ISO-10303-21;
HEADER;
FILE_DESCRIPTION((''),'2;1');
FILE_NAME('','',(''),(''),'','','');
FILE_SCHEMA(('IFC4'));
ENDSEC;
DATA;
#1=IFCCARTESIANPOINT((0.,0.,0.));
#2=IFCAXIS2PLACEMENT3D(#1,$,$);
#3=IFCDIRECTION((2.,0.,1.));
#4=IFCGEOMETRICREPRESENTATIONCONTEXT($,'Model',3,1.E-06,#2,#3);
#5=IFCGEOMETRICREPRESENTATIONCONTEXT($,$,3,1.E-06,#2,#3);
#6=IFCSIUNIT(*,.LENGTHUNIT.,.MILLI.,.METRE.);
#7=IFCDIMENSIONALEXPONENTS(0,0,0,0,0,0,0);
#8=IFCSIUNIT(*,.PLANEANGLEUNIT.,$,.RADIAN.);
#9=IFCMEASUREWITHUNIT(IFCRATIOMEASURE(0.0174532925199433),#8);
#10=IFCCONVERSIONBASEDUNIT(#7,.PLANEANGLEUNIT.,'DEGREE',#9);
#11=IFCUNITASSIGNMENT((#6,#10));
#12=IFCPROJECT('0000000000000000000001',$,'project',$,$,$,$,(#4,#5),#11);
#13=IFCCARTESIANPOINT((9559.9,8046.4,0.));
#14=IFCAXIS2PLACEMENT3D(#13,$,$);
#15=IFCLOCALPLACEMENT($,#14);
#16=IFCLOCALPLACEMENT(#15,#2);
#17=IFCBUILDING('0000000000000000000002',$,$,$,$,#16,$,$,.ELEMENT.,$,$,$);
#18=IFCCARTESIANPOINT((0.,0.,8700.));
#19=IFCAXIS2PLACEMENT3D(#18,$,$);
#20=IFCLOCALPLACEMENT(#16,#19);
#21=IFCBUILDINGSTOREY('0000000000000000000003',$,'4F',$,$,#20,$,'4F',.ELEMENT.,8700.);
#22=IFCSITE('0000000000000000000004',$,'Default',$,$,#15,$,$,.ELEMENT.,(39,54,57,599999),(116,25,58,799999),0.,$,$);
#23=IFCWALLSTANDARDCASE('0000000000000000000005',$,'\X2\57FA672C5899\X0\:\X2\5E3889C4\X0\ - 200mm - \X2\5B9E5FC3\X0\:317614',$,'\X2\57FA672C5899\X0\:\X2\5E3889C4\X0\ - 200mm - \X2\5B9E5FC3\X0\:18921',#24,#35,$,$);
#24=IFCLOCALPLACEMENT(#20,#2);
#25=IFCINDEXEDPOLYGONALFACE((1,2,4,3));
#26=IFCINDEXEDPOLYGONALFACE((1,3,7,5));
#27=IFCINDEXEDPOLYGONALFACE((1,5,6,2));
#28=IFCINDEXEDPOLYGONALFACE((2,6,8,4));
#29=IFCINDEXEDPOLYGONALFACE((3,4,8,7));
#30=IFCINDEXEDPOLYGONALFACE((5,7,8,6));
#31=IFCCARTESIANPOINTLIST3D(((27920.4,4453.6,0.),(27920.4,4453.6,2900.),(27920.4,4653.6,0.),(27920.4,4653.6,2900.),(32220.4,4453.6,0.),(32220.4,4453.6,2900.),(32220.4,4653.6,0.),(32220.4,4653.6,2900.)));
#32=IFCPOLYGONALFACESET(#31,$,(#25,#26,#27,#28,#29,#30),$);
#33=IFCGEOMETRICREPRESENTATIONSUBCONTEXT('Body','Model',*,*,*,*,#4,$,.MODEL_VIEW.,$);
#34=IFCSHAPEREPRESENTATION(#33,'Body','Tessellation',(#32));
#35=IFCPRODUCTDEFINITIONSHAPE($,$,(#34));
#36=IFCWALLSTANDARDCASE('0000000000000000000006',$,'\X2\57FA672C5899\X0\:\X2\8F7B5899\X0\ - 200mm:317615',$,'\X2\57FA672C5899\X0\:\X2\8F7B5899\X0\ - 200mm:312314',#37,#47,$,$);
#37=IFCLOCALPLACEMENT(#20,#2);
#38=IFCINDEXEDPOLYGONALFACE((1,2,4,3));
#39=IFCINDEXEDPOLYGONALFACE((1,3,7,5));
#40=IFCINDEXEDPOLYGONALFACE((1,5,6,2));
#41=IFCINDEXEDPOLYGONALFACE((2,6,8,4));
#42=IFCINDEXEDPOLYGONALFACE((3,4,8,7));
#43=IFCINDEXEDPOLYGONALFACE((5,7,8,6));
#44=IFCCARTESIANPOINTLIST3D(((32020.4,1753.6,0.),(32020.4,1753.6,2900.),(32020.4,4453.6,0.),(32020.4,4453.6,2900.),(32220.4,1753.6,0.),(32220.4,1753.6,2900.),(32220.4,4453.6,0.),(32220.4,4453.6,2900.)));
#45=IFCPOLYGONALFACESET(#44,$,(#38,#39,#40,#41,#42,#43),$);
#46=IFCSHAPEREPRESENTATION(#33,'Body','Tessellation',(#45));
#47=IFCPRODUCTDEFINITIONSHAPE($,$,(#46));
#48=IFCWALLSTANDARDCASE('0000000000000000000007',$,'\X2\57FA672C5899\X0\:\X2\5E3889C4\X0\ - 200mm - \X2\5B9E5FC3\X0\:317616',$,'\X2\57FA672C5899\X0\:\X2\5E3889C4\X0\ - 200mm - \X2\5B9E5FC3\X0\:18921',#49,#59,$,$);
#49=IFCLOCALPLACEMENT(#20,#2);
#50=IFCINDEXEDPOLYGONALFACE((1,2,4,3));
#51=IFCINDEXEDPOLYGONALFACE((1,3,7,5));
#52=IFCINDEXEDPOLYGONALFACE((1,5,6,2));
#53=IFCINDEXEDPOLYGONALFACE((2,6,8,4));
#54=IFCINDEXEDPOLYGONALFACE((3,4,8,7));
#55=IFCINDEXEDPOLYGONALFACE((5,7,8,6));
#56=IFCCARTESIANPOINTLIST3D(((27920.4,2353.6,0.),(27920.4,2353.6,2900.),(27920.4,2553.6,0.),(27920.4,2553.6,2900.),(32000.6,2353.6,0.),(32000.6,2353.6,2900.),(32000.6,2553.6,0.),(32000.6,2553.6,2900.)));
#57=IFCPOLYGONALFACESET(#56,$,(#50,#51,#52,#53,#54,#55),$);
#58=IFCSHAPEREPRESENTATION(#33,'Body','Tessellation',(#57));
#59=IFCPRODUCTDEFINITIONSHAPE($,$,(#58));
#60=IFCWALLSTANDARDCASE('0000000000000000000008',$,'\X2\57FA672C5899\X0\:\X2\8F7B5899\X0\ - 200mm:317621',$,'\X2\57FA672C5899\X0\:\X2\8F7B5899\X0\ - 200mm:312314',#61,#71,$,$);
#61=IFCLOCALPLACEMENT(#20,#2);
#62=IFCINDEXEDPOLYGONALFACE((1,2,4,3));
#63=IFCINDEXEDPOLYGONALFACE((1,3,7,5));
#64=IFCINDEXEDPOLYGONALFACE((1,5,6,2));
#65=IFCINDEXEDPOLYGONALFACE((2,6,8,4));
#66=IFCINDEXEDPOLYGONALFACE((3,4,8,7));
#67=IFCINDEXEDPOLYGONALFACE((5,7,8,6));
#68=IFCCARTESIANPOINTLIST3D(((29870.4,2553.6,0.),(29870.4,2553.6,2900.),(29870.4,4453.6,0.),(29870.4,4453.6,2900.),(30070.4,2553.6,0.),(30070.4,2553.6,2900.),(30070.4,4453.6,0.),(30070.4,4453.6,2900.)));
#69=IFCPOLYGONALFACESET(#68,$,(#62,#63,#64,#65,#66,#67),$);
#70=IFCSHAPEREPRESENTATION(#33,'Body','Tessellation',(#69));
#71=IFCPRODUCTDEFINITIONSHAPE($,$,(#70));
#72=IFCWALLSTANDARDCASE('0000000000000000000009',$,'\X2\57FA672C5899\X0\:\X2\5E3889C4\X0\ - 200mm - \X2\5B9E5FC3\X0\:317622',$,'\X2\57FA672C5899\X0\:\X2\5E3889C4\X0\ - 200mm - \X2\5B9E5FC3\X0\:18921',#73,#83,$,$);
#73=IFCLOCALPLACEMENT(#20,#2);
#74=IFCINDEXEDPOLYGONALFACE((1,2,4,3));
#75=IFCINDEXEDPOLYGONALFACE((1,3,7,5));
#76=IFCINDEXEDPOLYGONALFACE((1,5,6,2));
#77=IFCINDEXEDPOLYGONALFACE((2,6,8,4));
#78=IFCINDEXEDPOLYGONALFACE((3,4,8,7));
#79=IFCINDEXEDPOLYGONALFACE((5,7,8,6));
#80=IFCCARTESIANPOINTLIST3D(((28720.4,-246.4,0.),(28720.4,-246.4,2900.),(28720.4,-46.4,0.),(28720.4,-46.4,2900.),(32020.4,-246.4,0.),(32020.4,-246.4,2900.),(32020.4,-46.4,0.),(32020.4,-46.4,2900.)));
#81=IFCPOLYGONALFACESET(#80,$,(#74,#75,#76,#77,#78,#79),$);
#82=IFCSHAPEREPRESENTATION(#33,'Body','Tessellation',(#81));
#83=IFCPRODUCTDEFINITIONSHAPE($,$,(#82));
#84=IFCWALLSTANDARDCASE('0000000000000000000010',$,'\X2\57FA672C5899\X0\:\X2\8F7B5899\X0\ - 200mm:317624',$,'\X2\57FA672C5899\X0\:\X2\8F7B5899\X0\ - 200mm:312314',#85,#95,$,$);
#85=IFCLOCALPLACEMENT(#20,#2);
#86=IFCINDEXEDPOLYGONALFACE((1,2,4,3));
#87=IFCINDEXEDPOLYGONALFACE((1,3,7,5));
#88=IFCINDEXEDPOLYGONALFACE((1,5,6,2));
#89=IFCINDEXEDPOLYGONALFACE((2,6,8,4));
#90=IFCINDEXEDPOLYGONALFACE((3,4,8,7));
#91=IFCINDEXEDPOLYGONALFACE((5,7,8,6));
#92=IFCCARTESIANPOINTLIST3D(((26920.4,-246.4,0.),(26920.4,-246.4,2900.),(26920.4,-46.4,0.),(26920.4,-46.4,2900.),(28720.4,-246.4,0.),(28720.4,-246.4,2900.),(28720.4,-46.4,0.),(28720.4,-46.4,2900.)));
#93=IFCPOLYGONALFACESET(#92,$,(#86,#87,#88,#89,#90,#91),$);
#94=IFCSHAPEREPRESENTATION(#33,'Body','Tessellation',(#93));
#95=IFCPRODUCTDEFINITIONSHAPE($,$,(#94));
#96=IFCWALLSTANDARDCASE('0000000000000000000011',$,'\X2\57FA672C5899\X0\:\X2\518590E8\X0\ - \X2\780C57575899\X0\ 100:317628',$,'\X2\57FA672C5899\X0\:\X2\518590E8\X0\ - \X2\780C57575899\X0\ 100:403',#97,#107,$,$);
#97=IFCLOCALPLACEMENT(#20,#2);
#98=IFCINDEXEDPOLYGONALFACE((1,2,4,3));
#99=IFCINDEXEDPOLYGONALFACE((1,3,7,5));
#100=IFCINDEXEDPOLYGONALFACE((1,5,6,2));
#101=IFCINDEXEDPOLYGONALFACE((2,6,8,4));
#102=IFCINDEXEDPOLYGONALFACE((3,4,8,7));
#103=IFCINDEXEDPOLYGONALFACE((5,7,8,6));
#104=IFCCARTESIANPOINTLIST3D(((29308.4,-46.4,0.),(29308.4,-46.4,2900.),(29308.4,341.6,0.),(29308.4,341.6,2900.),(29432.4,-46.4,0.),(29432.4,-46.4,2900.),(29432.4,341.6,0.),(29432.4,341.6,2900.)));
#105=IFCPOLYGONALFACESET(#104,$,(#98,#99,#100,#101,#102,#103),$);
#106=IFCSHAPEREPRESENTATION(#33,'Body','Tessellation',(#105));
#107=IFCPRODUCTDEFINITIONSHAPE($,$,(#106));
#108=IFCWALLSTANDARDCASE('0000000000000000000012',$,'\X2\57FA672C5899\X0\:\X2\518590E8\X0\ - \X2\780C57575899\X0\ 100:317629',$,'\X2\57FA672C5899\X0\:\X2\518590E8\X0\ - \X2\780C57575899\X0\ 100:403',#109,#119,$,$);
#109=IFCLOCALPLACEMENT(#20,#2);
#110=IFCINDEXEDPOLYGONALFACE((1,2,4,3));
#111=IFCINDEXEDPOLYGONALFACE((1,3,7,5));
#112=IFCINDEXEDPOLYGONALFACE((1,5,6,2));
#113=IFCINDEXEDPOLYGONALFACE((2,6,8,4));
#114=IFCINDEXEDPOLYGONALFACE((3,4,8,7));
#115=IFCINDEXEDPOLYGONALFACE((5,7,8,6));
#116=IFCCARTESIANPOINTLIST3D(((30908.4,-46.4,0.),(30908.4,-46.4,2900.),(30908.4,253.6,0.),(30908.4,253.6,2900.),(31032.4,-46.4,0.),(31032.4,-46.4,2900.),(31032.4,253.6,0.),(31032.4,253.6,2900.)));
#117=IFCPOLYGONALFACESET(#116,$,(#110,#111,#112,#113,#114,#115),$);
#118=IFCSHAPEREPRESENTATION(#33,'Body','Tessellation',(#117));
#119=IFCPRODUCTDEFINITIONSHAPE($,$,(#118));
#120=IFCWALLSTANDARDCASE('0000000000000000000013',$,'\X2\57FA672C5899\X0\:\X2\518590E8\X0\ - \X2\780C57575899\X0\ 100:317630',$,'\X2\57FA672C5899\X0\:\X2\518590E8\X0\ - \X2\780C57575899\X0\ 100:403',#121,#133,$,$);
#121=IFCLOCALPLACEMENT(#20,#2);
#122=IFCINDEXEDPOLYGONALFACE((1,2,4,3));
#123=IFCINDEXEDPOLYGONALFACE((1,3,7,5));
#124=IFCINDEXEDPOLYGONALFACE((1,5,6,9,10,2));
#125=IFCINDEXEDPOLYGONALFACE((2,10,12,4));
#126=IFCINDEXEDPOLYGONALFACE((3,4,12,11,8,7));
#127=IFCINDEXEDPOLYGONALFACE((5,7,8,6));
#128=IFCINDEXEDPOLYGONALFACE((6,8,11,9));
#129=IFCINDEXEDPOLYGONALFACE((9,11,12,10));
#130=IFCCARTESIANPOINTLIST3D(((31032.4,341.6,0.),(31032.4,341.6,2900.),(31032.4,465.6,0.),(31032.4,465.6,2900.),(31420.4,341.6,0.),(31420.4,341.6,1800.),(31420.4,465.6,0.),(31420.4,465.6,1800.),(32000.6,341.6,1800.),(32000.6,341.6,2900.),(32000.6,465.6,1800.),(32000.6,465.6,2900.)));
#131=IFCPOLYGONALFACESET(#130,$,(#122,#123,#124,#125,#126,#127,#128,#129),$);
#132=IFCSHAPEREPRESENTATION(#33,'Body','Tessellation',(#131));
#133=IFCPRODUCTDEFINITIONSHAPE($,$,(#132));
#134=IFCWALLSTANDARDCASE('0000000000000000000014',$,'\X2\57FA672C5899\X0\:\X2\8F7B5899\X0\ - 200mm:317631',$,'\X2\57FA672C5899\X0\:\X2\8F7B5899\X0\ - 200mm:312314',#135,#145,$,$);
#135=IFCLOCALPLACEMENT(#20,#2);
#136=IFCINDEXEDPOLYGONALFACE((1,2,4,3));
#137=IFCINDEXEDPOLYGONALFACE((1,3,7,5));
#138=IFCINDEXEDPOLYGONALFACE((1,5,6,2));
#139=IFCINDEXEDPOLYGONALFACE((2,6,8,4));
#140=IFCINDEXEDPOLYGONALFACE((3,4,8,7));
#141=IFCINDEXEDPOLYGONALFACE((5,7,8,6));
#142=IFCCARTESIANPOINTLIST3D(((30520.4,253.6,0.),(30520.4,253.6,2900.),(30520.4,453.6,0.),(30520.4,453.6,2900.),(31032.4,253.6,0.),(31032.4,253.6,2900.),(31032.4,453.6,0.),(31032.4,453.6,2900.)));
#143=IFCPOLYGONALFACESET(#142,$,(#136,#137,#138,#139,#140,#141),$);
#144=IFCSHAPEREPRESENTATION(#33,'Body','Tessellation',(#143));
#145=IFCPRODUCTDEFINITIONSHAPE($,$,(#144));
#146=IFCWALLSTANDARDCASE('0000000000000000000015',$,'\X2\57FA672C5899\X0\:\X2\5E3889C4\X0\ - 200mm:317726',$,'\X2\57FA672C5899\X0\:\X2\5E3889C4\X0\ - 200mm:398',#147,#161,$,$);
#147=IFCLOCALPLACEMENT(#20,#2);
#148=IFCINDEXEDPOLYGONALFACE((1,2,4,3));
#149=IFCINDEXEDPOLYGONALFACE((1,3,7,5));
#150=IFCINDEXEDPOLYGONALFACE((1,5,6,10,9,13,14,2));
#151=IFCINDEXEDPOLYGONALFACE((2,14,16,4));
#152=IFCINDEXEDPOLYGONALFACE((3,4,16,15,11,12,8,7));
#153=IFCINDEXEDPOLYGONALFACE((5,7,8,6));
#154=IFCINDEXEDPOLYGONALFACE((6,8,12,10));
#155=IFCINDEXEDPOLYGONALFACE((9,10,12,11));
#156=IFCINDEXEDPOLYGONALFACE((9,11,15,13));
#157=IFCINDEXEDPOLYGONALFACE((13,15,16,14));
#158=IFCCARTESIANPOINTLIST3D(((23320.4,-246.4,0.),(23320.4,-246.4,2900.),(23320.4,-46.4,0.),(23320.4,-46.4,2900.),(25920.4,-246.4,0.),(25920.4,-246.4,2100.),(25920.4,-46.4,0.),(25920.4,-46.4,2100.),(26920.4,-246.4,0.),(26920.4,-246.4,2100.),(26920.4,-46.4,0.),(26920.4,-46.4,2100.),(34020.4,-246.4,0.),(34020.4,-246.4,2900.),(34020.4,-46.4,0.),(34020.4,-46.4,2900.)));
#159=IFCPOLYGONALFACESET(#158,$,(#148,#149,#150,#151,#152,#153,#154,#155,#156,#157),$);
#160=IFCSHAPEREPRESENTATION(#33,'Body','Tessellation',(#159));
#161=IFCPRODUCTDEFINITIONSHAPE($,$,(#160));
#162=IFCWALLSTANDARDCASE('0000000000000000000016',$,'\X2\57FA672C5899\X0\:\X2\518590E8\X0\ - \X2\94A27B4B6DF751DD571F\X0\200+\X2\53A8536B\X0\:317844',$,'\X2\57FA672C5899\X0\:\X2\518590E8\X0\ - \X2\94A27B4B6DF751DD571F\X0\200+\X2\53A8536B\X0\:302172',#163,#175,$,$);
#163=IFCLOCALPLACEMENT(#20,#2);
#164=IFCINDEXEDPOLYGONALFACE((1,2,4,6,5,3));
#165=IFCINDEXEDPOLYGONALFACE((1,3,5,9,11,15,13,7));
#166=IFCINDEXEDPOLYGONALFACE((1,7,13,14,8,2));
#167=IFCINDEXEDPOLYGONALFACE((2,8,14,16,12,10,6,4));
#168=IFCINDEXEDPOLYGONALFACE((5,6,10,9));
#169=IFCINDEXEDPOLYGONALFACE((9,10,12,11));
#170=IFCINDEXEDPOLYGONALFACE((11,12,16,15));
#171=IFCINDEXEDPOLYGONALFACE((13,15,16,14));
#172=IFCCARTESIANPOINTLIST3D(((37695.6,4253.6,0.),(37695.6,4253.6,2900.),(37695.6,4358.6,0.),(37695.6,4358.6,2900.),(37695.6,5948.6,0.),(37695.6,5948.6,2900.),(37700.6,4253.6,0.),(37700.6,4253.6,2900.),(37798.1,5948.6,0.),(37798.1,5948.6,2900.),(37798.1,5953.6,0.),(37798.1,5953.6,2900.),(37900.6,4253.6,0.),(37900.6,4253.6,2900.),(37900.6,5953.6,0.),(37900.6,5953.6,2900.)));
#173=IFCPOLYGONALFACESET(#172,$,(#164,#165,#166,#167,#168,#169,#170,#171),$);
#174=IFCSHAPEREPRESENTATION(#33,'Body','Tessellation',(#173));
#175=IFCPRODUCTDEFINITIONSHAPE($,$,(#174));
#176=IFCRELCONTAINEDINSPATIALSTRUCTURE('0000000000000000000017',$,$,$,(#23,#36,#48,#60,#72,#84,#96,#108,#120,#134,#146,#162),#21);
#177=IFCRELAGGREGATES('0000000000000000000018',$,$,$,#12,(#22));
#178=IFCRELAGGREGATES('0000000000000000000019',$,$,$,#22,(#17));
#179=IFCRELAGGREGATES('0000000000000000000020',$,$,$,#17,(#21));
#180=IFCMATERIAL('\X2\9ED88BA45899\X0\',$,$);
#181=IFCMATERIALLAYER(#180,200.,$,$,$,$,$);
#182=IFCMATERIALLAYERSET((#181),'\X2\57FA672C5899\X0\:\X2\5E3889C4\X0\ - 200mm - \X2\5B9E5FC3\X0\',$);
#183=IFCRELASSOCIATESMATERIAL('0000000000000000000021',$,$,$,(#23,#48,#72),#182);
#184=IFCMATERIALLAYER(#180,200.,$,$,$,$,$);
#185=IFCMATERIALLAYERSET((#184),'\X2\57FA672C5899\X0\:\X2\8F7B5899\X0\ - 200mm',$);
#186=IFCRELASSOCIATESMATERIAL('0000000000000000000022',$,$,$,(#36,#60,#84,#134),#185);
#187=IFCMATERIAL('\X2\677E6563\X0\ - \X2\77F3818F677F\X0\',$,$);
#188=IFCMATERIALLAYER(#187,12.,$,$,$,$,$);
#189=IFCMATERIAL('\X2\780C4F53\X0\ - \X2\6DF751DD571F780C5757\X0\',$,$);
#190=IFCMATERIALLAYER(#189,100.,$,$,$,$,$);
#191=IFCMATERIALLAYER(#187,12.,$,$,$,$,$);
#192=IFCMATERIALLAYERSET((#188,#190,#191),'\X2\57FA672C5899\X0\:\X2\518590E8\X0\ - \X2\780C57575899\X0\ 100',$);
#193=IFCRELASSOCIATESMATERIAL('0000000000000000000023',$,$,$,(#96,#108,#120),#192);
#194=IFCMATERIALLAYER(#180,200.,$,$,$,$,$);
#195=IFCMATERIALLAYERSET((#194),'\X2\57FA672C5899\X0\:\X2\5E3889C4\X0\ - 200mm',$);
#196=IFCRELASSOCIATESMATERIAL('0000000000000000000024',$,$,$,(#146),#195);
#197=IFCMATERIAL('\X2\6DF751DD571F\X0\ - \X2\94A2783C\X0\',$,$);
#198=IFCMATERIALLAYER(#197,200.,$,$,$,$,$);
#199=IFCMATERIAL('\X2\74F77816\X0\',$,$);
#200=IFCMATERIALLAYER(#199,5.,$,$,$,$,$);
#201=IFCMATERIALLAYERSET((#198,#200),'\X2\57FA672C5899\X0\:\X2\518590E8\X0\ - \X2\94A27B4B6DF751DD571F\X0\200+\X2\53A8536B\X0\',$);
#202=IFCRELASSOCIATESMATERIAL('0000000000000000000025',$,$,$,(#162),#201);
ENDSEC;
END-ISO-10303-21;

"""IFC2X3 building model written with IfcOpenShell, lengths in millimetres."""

from ifc_helpers import new_model, entity, si_unit, converted_unit, direction, frame, frame_2d, origin, place, context, subcontext, project, spatial, polyline, rectangle, outline, extrude, material, layer, layer_set, layer_usage, element, save


model = new_model("IFC2X3")

# Units and contexts
model_context = context("Model", 3, precision=1e-06, world=origin(), true_north=direction((2.0, 0.0, 1.0)))
context_of_model = context(None, 3, precision=1e-06, world=origin(), true_north=direction((2.0, 0.0, 1.0)))
body_context = subcontext(model_context, "Body", "Model", "MODEL_VIEW")
ifc_project = project(units=[si_unit("LENGTHUNIT", "METRE", prefix="MILLI"), converted_unit("PLANEANGLEUNIT", "DEGREE", entity("IfcRatioMeasure", 0.0174532925199433), si_unit("PLANEANGLEUNIT", "RADIAN"), dimensions=[0, 0, 0, 0, 0, 0, 0])], contexts=[model_context, context_of_model])

# Site, building, storey
site_placement = place(None, frame((9559.9, 8046.4, 0.0)))
site = spatial("IfcSite", under=ifc_project, at=site_placement, Name="Default", CompositionType="ELEMENT", RefLatitude=(39, 54, 57, 599999), RefLongitude=(116, 25, 58, 799999), RefElevation=0.0)
building_placement = place(site_placement, origin())
building = spatial("IfcBuilding", under=site, at=building_placement, CompositionType="ELEMENT")
storey_placement = place(building_placement, frame((0.0, 0.0, 8700.0)))
storey = spatial("IfcBuildingStorey", under=building, at=storey_placement, Name="4F", LongName="4F", CompositionType="ELEMENT", Elevation=8700.0)

# Walls
ifc_material_1 = material(Name="默认墙")
ifc_layer_1 = layer(ifc_material_1, 200.0)
ifc_layer_set_1 = layer_set([ifc_layer_1], Name="基本墙:常规 - 200mm - 实心")
ifc_layer_usage_1 = layer_usage(ifc_layer_set_1, "AXIS2", "POSITIVE", -100.0)
wall_1_placement = place(storey_placement, frame((32220.4, 4553.6, 0.0), z_axis=(0.0, 0.0, 1.0), x_axis=(-1.0, 0.0, 0.0)))
element("IfcWallStandardCase", 1, at=wall_1_placement, inside=storey, material=ifc_layer_usage_1, Name="基本墙:常规 - 200mm - 实心:317614", ObjectType="基本墙:常规 - 200mm - 实心:18921", context=body_context, shape_type="SweptSolid", body=[
    extrude(rectangle(XDim=4300.0, YDim=200.0, at=frame_2d((2150.0, 0.0), x_axis=(-1.0, 0.0))), origin(), (0.0, 0.0, 1.0), 2900.0),
])
ifc_layer_2 = layer(ifc_material_1, 200.0)
ifc_layer_set_2 = layer_set([ifc_layer_2], Name="基本墙:轻墙 - 200mm")
ifc_layer_usage_2 = layer_usage(ifc_layer_set_2, "AXIS2", "POSITIVE", -100.0)
wall_2_placement = place(storey_placement, frame((32120.4, 4453.6, 0.0), z_axis=(0.0, 0.0, 1.0), x_axis=(0.0, -1.0, 0.0)))
element("IfcWallStandardCase", 2, at=wall_2_placement, inside=storey, material=ifc_layer_usage_2, Name="基本墙:轻墙 - 200mm:317615", ObjectType="基本墙:轻墙 - 200mm:312314", context=body_context, shape_type="SweptSolid", body=[
    extrude(rectangle(XDim=2700.0, YDim=200.0, at=frame_2d((1350.0, 0.0), x_axis=(-1.0, 0.0))), origin(), (0.0, 0.0, 1.0), 2900.0),
])
ifc_layer_usage_3 = layer_usage(ifc_layer_set_1, "AXIS2", "POSITIVE", -100.0)
wall_3_placement = place(storey_placement, frame((27920.4, 2453.6, 0.0)))
element("IfcWallStandardCase", 3, at=wall_3_placement, inside=storey, material=ifc_layer_usage_3, Name="基本墙:常规 - 200mm - 实心:317616", ObjectType="基本墙:常规 - 200mm - 实心:18921", context=body_context, shape_type="SweptSolid", body=[
    extrude(rectangle(XDim=4080.2, YDim=200.0, at=frame_2d((2040.1, 0.0), x_axis=(-1.0, 0.0))), origin(), (0.0, 0.0, 1.0), 2900.0),
])
ifc_layer_usage_4 = layer_usage(ifc_layer_set_2, "AXIS2", "POSITIVE", -100.0)
wall_4_placement = place(storey_placement, frame((29970.4, 4453.6, 0.0), z_axis=(0.0, 0.0, 1.0), x_axis=(0.0, -1.0, 0.0)))
element("IfcWallStandardCase", 4, at=wall_4_placement, inside=storey, material=ifc_layer_usage_4, Name="基本墙:轻墙 - 200mm:317621", ObjectType="基本墙:轻墙 - 200mm:312314", context=body_context, shape_type="SweptSolid", body=[
    extrude(rectangle(XDim=1900.0, YDim=200.0, at=frame_2d((950.0, 0.0), x_axis=(-1.0, 0.0))), origin(), (0.0, 0.0, 1.0), 2900.0),
])
ifc_layer_usage_5 = layer_usage(ifc_layer_set_1, "AXIS2", "POSITIVE", -100.0)
wall_5_placement = place(storey_placement, frame((32020.4, -146.4, 0.0), z_axis=(0.0, 0.0, 1.0), x_axis=(-1.0, 0.0, 0.0)))
element("IfcWallStandardCase", 5, at=wall_5_placement, inside=storey, material=ifc_layer_usage_5, Name="基本墙:常规 - 200mm - 实心:317622", ObjectType="基本墙:常规 - 200mm - 实心:18921", context=body_context, shape_type="SweptSolid", body=[
    extrude(rectangle(XDim=3300.0, YDim=200.0, at=frame_2d((1650.0, 0.0), x_axis=(-1.0, 0.0))), origin(), (0.0, 0.0, 1.0), 2900.0),
])
ifc_layer_usage_6 = layer_usage(ifc_layer_set_2, "AXIS2", "POSITIVE", -100.0)
wall_6_placement = place(storey_placement, frame((28720.4, -146.4, 0.0), z_axis=(0.0, 0.0, 1.0), x_axis=(-1.0, 0.0, 0.0)))
element("IfcWallStandardCase", 6, at=wall_6_placement, inside=storey, material=ifc_layer_usage_6, Name="基本墙:轻墙 - 200mm:317624", ObjectType="基本墙:轻墙 - 200mm:312314", context=body_context, shape_type="SweptSolid", body=[
    extrude(rectangle(XDim=1800.0, YDim=200.0, at=frame_2d((900.0, 0.0), x_axis=(-1.0, 0.0))), origin(), (0.0, 0.0, 1.0), 2900.0),
])
ifc_material_2 = material(Name="松散 - 石膏板")
ifc_layer_3 = layer(ifc_material_2, 12.0)
ifc_material_3 = material(Name="砌体 - 混凝土砌块")
ifc_layer_4 = layer(ifc_material_3, 100.0)
ifc_layer_5 = layer(ifc_material_2, 12.0)
ifc_layer_set_3 = layer_set([ifc_layer_3, ifc_layer_4, ifc_layer_5], Name="基本墙:内部 - 砌块墙 100")
ifc_layer_usage_7 = layer_usage(ifc_layer_set_3, "AXIS2", "POSITIVE", -62.0)
wall_7_placement = place(storey_placement, frame((29370.4, 341.6, 0.0), z_axis=(0.0, 0.0, 1.0), x_axis=(0.0, -1.0, 0.0)))
element("IfcWallStandardCase", 7, at=wall_7_placement, inside=storey, material=ifc_layer_usage_7, Name="基本墙:内部 - 砌块墙 100:317628", ObjectType="基本墙:内部 - 砌块墙 100:403", context=body_context, shape_type="SweptSolid", body=[
    extrude(rectangle(XDim=388.0, YDim=124.0, at=frame_2d((194.0, 0.0), x_axis=(-1.0, 0.0))), origin(), (0.0, 0.0, 1.0), 2900.0),
])
ifc_layer_usage_8 = layer_usage(ifc_layer_set_3, "AXIS2", "POSITIVE", -62.0)
wall_8_placement = place(storey_placement, frame((30970.4, -46.4, 0.0), z_axis=(0.0, 0.0, 1.0), x_axis=(0.0, 1.0, 0.0)))
element("IfcWallStandardCase", 8, at=wall_8_placement, inside=storey, material=ifc_layer_usage_8, Name="基本墙:内部 - 砌块墙 100:317629", ObjectType="基本墙:内部 - 砌块墙 100:403", context=body_context, shape_type="SweptSolid", body=[
    extrude(rectangle(XDim=300.0, YDim=124.0, at=frame_2d((150.0, 0.0), x_axis=(-1.0, 0.0))), origin(), (0.0, 0.0, 1.0), 2900.0),
])

# Wall, opening
ifc_layer_usage_9 = layer_usage(ifc_layer_set_3, "AXIS2", "POSITIVE", -62.0)
wall_9_placement = place(storey_placement, frame((31032.4, 403.6, 0.0)))
wall_9 = element("IfcWallStandardCase", 9, at=wall_9_placement, inside=storey, material=ifc_layer_usage_9, Name="基本墙:内部 - 砌块墙 100:317630", ObjectType="基本墙:内部 - 砌块墙 100:403", context=body_context, shape_type="SweptSolid", body=[
    extrude(rectangle(XDim=968.2, YDim=124.0, at=frame_2d((484.1, 0.0), x_axis=(-1.0, 0.0))), origin(), (0.0, 0.0, 1.0), 2900.0),
])
opening_1_placement = place(wall_9_placement, frame((388.0, -62.0, 0.0)))
element("IfcOpeningElement", 10, at=opening_1_placement, cuts=wall_9, ObjectType="Opening", context=body_context, shape_type="SweptSolid", body=[
    extrude(rectangle(XDim=1800.0, YDim=600.0, at=frame_2d((900.0, 300.0), x_axis=(1.0, 0.0))), frame((0.0, 0.0, 0.0), z_axis=(0.0, 1.0, 0.0), x_axis=(0.0, 0.0, 1.0)), (0.0, 0.0, 1.0), 124.0),
])

# Wall
ifc_layer_usage_10 = layer_usage(ifc_layer_set_2, "AXIS2", "POSITIVE", -100.0)
wall_10_placement = place(storey_placement, frame((31032.4, 353.6, 0.0), z_axis=(0.0, 0.0, 1.0), x_axis=(-1.0, 0.0, 0.0)))
element("IfcWallStandardCase", 11, at=wall_10_placement, inside=storey, material=ifc_layer_usage_10, Name="基本墙:轻墙 - 200mm:317631", ObjectType="基本墙:轻墙 - 200mm:312314", context=body_context, shape_type="SweptSolid", body=[
    extrude(rectangle(XDim=512.0, YDim=200.0, at=frame_2d((256.0, 0.0), x_axis=(-1.0, 0.0))), origin(), (0.0, 0.0, 1.0), 2900.0),
])

# Wall, opening
ifc_layer_6 = layer(ifc_material_1, 200.0)
ifc_layer_set_4 = layer_set([ifc_layer_6], Name="基本墙:常规 - 200mm")
ifc_layer_usage_11 = layer_usage(ifc_layer_set_4, "AXIS2", "POSITIVE", -100.0)
wall_11_placement = place(storey_placement, frame((34020.4, -146.4, 0.0), z_axis=(0.0, 0.0, 1.0), x_axis=(-1.0, 0.0, 0.0)))
wall_11 = element("IfcWallStandardCase", 12, at=wall_11_placement, inside=storey, material=ifc_layer_usage_11, Name="基本墙:常规 - 200mm:317726", ObjectType="基本墙:常规 - 200mm:398", context=body_context, shape_type="SweptSolid", body=[
    extrude(rectangle(XDim=10700.0, YDim=200.0, at=frame_2d((5350.0, 0.0), x_axis=(-1.0, 0.0))), origin(), (0.0, 0.0, 1.0), 2900.0),
])
opening_2_placement = place(wall_11_placement, frame((8100.0, 100.0, 0.0)))
element("IfcOpeningElement", 13, at=opening_2_placement, cuts=wall_11, ObjectType="Opening", context=body_context, shape_type="SweptSolid", body=[
    extrude(rectangle(XDim=2100.0, YDim=1000.0, at=frame_2d((1050.0, 500.0), x_axis=(1.0, 0.0))), frame((0.0, 0.0, 0.0), z_axis=(0.0, -1.0, 0.0), x_axis=(0.0, 0.0, 1.0)), (0.0, 0.0, 1.0), 200.0),
])

# Wall
ifc_material_4 = material(Name="混凝土 - 钢砼")
ifc_layer_7 = layer(ifc_material_4, 200.0)
ifc_material_5 = material(Name="瓷砖")
ifc_layer_8 = layer(ifc_material_5, 5.0)
ifc_layer_set_5 = layer_set([ifc_layer_7, ifc_layer_8], Name="基本墙:内部 - 钢筋混凝土200+厨卫")
ifc_layer_usage_12 = layer_usage(ifc_layer_set_5, "AXIS2", "NEGATIVE", 102.5)
wall_12_placement = place(storey_placement, frame((37798.1, 5953.6, 0.0), z_axis=(0.0, 0.0, 1.0), x_axis=(0.0, -1.0, 0.0)))
element("IfcWallStandardCase", 14, at=wall_12_placement, inside=storey, material=ifc_layer_usage_12, Name="基本墙:内部 - 钢筋混凝土200+厨卫:317844", ObjectType="基本墙:内部 - 钢筋混凝土200+厨卫:302172", context=body_context, shape_type="SweptSolid", body=[
    extrude(outline(polyline([(1700.0, -102.5), (1700.0, -97.5), (1700.0, 102.5), (0.0, 102.5), (0.0, 0.0), (5.0, 0.0), (5.0, -102.5), (1595.0, -102.5), (1700.0, -102.5)])), origin(), (0.0, 0.0, 1.0), 2900.0),
])

save(model, "model.ifc")
